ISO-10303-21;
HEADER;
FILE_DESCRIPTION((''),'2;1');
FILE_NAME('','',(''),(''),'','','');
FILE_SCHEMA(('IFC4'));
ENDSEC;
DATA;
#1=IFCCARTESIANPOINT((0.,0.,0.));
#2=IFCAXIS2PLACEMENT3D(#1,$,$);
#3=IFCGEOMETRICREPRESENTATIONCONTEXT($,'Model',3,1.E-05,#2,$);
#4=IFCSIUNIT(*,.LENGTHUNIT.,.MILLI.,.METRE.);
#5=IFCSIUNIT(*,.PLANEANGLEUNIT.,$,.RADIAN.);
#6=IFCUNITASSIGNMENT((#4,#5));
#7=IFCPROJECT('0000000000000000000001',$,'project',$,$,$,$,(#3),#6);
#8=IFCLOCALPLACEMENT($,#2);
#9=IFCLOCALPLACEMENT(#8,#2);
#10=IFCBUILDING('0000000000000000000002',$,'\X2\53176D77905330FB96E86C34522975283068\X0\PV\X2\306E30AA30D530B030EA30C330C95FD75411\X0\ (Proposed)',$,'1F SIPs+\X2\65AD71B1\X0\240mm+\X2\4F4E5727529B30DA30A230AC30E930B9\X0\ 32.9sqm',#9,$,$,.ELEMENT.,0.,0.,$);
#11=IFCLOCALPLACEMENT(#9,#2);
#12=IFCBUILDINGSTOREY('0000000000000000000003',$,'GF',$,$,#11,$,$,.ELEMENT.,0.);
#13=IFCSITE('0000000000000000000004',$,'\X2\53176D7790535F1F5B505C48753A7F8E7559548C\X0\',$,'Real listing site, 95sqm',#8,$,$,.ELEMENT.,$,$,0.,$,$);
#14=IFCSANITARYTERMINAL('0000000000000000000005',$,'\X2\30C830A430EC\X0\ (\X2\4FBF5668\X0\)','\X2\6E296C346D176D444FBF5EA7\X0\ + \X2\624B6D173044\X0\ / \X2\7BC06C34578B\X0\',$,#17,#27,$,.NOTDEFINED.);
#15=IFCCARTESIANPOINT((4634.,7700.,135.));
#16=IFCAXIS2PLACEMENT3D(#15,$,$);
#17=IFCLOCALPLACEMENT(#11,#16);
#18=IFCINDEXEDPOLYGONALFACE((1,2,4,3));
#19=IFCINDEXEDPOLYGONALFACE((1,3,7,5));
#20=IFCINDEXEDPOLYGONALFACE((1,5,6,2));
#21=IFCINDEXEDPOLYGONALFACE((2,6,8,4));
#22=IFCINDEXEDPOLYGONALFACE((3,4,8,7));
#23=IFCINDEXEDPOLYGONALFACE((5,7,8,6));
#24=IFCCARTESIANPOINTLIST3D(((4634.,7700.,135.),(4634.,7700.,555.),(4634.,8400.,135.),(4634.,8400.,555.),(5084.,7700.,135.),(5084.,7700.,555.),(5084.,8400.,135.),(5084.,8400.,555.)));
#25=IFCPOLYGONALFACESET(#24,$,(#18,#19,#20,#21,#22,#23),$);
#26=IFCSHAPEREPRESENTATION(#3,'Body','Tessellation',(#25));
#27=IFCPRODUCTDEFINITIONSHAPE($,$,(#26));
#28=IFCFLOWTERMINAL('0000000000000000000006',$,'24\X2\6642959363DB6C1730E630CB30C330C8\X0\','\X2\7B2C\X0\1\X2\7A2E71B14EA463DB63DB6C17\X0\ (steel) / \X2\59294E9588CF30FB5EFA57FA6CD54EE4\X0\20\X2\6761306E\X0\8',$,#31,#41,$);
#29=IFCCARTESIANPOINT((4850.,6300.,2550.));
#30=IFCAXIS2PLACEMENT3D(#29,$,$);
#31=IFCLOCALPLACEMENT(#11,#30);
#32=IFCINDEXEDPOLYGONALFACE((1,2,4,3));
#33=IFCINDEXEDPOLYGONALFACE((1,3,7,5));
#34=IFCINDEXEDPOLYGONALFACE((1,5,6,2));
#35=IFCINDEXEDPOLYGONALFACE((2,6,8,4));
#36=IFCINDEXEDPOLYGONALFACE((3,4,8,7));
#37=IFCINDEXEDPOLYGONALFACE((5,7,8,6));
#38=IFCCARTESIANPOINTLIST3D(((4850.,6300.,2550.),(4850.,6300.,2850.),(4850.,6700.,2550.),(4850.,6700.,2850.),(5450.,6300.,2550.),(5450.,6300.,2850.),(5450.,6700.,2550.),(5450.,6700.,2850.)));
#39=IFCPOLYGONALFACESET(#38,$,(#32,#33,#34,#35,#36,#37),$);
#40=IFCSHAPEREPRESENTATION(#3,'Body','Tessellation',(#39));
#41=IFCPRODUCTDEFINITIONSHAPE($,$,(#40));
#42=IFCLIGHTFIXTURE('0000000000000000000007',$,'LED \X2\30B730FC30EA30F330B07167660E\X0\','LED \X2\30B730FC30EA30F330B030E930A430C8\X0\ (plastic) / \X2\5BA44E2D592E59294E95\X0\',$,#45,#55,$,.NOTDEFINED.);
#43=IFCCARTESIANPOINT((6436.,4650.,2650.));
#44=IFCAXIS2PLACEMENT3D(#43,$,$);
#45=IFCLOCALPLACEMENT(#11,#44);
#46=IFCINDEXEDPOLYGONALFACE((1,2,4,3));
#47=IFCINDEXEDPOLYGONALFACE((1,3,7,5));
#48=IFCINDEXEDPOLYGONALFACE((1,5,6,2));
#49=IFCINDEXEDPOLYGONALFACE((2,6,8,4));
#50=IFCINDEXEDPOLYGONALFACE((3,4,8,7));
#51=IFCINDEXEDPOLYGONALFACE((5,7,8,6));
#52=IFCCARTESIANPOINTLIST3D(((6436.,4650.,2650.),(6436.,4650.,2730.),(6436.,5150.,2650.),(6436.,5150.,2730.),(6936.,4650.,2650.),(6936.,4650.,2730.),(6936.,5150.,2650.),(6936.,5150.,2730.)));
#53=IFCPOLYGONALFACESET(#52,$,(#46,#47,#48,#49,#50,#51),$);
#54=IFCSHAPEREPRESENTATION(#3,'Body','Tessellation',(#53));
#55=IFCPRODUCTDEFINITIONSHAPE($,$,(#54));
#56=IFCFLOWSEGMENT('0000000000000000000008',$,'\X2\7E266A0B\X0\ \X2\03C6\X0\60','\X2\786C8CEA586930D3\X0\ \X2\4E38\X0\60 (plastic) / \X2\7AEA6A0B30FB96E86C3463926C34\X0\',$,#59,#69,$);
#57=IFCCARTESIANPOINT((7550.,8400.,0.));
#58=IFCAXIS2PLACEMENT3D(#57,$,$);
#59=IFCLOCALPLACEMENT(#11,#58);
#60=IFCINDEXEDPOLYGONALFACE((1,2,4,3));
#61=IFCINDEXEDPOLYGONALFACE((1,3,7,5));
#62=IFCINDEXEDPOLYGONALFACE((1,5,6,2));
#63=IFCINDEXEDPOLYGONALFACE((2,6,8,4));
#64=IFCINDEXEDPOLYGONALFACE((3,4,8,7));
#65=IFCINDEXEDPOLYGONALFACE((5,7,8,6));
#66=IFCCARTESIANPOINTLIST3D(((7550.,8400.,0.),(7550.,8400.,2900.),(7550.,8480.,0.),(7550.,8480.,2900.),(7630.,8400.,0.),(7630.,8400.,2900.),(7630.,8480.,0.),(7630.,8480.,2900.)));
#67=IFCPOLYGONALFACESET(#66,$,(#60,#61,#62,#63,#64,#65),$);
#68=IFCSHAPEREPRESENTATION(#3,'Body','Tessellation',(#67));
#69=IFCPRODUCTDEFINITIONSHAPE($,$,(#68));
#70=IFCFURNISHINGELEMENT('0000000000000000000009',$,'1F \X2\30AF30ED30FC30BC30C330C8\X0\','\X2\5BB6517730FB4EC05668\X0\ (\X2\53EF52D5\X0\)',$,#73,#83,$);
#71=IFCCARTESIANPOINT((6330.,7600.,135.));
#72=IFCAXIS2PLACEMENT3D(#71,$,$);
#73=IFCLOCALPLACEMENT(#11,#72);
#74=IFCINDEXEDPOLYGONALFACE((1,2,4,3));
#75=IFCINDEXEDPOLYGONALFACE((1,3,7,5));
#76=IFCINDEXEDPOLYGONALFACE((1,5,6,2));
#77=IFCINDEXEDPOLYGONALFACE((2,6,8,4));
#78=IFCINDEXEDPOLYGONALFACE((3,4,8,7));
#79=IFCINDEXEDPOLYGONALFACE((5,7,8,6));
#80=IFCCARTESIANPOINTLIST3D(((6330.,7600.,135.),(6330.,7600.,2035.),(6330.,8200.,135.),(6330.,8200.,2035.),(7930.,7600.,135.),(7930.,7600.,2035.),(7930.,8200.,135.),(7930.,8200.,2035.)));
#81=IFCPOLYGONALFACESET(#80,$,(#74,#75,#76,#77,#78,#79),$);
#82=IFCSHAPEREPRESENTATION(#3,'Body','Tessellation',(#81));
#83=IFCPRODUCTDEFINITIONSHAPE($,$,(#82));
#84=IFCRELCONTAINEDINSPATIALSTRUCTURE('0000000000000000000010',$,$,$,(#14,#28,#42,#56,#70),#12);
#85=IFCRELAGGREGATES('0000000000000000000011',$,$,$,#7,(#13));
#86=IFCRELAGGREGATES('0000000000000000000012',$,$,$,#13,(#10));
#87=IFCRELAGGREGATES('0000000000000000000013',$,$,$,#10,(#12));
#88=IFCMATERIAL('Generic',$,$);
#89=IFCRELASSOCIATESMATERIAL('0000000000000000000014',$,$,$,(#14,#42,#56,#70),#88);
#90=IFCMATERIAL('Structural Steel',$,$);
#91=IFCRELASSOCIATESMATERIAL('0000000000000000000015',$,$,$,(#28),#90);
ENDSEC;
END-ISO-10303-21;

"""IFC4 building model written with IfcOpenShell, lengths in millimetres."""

from ifc_helpers import new_model, si_unit, frame, frame_2d, origin, place, context, project, spatial, rectangle, extrude, material, element, save


model = new_model("IFC4")

# Units and contexts
model_context = context("Model", 3, precision=1e-05, world=origin())
ifc_project = project(units=[si_unit("LENGTHUNIT", "METRE", prefix="MILLI"), si_unit("PLANEANGLEUNIT", "RADIAN")], contexts=[model_context])

# Site, building, storey
site_placement = place(None, origin())
site = spatial("IfcSite", under=ifc_project, at=site_placement, Name="北海道弟子屈町美留和", ObjectType="Real listing site, 95sqm", CompositionType="ELEMENT", RefElevation=0.0)
building_placement = place(site_placement, origin())
building = spatial("IfcBuilding", under=site, at=building_placement, Name="北海道・雨水利用とPVのオフグリッド志向 (Proposed)", ObjectType="1F SIPs+断熱240mm+低圧力ペアガラス 32.9sqm", CompositionType="ELEMENT", ElevationOfRefHeight=0.0, ElevationOfTerrain=0.0)
storey_placement = place(building_placement, origin())
storey = spatial("IfcBuildingStorey", under=building, at=storey_placement, Name="GF", CompositionType="ELEMENT", Elevation=0.0)

# Shared definitions
ifc_material_1 = material(Name="Generic")

# Sanitary terminal
sanitary_terminal_placement = place(storey_placement, frame((4634.0, 7700.0, 135.0)))
element("IfcSanitaryTerminal", 1, at=sanitary_terminal_placement, inside=storey, material=ifc_material_1, Name="トイレ (便器)", Description="温水洗浄便座 + 手洗い / 節水型", PredefinedType="NOTDEFINED", context=model_context, shape_type="SweptSolid", body=[
    extrude(rectangle(XDim=450.0, YDim=700.0, at=frame_2d((225.0, 350.0))), frame((4634.0, 7700.0, 135.0)), (0.0, 0.0, 1.0), 420.0),
])

# Flow terminal
ifc_material_2 = material(Name="Structural Steel")
flow_terminal_placement = place(storey_placement, frame((4850.0, 6300.0, 2550.0)))
element("IfcFlowTerminal", 2, at=flow_terminal_placement, inside=storey, material=ifc_material_2, Name="24時間換気ユニット", Description="第1種熱交換換気 (steel) / 天井裏・建基法令20条の8", context=model_context, shape_type="SweptSolid", body=[
    extrude(rectangle(XDim=600.0, YDim=400.0, at=frame_2d((300.0, 200.0))), frame((4850.0, 6300.0, 2550.0)), (0.0, 0.0, 1.0), 300.0),
])

# Light fixture
light_fixture_placement = place(storey_placement, frame((6436.0, 4650.0, 2650.0)))
element("IfcLightFixture", 3, at=light_fixture_placement, inside=storey, material=ifc_material_1, Name="LED シーリング照明", Description="LED シーリングライト (plastic) / 室中央天井", PredefinedType="NOTDEFINED", context=model_context, shape_type="SweptSolid", body=[
    extrude(rectangle(XDim=500.0, YDim=500.0, at=frame_2d((250.0, 250.0))), frame((6436.0, 4650.0, 2650.0)), (0.0, 0.0, 1.0), 80.0),
])

# Flow segment
flow_segment_placement = place(storey_placement, frame((7550.0, 8400.0, 0.0)))
element("IfcFlowSegment", 4, at=flow_segment_placement, inside=storey, material=ifc_material_1, Name="縦樋 φ60", Description="硬質塩ビ 丸60 (plastic) / 竪樋・雨水排水", context=model_context, shape_type="SweptSolid", body=[
    extrude(rectangle(XDim=80.0, YDim=80.0, at=frame_2d((40.0, 40.0))), frame((7550.0, 8400.0, 0.0)), (0.0, 0.0, 1.0), 2900.0),
])

# Furnishing element
furnishing_placement = place(storey_placement, frame((6330.0, 7600.0, 135.0)))
element("IfcFurnishingElement", 5, at=furnishing_placement, inside=storey, material=ifc_material_1, Name="1F クローゼット", Description="家具・什器 (可動)", context=model_context, shape_type="SweptSolid", body=[
    extrude(rectangle(XDim=1600.0, YDim=600.0, at=frame_2d((800.0, 300.0))), frame((6330.0, 7600.0, 135.0)), (0.0, 0.0, 1.0), 1900.0),
])

save(model, "model.ifc")
